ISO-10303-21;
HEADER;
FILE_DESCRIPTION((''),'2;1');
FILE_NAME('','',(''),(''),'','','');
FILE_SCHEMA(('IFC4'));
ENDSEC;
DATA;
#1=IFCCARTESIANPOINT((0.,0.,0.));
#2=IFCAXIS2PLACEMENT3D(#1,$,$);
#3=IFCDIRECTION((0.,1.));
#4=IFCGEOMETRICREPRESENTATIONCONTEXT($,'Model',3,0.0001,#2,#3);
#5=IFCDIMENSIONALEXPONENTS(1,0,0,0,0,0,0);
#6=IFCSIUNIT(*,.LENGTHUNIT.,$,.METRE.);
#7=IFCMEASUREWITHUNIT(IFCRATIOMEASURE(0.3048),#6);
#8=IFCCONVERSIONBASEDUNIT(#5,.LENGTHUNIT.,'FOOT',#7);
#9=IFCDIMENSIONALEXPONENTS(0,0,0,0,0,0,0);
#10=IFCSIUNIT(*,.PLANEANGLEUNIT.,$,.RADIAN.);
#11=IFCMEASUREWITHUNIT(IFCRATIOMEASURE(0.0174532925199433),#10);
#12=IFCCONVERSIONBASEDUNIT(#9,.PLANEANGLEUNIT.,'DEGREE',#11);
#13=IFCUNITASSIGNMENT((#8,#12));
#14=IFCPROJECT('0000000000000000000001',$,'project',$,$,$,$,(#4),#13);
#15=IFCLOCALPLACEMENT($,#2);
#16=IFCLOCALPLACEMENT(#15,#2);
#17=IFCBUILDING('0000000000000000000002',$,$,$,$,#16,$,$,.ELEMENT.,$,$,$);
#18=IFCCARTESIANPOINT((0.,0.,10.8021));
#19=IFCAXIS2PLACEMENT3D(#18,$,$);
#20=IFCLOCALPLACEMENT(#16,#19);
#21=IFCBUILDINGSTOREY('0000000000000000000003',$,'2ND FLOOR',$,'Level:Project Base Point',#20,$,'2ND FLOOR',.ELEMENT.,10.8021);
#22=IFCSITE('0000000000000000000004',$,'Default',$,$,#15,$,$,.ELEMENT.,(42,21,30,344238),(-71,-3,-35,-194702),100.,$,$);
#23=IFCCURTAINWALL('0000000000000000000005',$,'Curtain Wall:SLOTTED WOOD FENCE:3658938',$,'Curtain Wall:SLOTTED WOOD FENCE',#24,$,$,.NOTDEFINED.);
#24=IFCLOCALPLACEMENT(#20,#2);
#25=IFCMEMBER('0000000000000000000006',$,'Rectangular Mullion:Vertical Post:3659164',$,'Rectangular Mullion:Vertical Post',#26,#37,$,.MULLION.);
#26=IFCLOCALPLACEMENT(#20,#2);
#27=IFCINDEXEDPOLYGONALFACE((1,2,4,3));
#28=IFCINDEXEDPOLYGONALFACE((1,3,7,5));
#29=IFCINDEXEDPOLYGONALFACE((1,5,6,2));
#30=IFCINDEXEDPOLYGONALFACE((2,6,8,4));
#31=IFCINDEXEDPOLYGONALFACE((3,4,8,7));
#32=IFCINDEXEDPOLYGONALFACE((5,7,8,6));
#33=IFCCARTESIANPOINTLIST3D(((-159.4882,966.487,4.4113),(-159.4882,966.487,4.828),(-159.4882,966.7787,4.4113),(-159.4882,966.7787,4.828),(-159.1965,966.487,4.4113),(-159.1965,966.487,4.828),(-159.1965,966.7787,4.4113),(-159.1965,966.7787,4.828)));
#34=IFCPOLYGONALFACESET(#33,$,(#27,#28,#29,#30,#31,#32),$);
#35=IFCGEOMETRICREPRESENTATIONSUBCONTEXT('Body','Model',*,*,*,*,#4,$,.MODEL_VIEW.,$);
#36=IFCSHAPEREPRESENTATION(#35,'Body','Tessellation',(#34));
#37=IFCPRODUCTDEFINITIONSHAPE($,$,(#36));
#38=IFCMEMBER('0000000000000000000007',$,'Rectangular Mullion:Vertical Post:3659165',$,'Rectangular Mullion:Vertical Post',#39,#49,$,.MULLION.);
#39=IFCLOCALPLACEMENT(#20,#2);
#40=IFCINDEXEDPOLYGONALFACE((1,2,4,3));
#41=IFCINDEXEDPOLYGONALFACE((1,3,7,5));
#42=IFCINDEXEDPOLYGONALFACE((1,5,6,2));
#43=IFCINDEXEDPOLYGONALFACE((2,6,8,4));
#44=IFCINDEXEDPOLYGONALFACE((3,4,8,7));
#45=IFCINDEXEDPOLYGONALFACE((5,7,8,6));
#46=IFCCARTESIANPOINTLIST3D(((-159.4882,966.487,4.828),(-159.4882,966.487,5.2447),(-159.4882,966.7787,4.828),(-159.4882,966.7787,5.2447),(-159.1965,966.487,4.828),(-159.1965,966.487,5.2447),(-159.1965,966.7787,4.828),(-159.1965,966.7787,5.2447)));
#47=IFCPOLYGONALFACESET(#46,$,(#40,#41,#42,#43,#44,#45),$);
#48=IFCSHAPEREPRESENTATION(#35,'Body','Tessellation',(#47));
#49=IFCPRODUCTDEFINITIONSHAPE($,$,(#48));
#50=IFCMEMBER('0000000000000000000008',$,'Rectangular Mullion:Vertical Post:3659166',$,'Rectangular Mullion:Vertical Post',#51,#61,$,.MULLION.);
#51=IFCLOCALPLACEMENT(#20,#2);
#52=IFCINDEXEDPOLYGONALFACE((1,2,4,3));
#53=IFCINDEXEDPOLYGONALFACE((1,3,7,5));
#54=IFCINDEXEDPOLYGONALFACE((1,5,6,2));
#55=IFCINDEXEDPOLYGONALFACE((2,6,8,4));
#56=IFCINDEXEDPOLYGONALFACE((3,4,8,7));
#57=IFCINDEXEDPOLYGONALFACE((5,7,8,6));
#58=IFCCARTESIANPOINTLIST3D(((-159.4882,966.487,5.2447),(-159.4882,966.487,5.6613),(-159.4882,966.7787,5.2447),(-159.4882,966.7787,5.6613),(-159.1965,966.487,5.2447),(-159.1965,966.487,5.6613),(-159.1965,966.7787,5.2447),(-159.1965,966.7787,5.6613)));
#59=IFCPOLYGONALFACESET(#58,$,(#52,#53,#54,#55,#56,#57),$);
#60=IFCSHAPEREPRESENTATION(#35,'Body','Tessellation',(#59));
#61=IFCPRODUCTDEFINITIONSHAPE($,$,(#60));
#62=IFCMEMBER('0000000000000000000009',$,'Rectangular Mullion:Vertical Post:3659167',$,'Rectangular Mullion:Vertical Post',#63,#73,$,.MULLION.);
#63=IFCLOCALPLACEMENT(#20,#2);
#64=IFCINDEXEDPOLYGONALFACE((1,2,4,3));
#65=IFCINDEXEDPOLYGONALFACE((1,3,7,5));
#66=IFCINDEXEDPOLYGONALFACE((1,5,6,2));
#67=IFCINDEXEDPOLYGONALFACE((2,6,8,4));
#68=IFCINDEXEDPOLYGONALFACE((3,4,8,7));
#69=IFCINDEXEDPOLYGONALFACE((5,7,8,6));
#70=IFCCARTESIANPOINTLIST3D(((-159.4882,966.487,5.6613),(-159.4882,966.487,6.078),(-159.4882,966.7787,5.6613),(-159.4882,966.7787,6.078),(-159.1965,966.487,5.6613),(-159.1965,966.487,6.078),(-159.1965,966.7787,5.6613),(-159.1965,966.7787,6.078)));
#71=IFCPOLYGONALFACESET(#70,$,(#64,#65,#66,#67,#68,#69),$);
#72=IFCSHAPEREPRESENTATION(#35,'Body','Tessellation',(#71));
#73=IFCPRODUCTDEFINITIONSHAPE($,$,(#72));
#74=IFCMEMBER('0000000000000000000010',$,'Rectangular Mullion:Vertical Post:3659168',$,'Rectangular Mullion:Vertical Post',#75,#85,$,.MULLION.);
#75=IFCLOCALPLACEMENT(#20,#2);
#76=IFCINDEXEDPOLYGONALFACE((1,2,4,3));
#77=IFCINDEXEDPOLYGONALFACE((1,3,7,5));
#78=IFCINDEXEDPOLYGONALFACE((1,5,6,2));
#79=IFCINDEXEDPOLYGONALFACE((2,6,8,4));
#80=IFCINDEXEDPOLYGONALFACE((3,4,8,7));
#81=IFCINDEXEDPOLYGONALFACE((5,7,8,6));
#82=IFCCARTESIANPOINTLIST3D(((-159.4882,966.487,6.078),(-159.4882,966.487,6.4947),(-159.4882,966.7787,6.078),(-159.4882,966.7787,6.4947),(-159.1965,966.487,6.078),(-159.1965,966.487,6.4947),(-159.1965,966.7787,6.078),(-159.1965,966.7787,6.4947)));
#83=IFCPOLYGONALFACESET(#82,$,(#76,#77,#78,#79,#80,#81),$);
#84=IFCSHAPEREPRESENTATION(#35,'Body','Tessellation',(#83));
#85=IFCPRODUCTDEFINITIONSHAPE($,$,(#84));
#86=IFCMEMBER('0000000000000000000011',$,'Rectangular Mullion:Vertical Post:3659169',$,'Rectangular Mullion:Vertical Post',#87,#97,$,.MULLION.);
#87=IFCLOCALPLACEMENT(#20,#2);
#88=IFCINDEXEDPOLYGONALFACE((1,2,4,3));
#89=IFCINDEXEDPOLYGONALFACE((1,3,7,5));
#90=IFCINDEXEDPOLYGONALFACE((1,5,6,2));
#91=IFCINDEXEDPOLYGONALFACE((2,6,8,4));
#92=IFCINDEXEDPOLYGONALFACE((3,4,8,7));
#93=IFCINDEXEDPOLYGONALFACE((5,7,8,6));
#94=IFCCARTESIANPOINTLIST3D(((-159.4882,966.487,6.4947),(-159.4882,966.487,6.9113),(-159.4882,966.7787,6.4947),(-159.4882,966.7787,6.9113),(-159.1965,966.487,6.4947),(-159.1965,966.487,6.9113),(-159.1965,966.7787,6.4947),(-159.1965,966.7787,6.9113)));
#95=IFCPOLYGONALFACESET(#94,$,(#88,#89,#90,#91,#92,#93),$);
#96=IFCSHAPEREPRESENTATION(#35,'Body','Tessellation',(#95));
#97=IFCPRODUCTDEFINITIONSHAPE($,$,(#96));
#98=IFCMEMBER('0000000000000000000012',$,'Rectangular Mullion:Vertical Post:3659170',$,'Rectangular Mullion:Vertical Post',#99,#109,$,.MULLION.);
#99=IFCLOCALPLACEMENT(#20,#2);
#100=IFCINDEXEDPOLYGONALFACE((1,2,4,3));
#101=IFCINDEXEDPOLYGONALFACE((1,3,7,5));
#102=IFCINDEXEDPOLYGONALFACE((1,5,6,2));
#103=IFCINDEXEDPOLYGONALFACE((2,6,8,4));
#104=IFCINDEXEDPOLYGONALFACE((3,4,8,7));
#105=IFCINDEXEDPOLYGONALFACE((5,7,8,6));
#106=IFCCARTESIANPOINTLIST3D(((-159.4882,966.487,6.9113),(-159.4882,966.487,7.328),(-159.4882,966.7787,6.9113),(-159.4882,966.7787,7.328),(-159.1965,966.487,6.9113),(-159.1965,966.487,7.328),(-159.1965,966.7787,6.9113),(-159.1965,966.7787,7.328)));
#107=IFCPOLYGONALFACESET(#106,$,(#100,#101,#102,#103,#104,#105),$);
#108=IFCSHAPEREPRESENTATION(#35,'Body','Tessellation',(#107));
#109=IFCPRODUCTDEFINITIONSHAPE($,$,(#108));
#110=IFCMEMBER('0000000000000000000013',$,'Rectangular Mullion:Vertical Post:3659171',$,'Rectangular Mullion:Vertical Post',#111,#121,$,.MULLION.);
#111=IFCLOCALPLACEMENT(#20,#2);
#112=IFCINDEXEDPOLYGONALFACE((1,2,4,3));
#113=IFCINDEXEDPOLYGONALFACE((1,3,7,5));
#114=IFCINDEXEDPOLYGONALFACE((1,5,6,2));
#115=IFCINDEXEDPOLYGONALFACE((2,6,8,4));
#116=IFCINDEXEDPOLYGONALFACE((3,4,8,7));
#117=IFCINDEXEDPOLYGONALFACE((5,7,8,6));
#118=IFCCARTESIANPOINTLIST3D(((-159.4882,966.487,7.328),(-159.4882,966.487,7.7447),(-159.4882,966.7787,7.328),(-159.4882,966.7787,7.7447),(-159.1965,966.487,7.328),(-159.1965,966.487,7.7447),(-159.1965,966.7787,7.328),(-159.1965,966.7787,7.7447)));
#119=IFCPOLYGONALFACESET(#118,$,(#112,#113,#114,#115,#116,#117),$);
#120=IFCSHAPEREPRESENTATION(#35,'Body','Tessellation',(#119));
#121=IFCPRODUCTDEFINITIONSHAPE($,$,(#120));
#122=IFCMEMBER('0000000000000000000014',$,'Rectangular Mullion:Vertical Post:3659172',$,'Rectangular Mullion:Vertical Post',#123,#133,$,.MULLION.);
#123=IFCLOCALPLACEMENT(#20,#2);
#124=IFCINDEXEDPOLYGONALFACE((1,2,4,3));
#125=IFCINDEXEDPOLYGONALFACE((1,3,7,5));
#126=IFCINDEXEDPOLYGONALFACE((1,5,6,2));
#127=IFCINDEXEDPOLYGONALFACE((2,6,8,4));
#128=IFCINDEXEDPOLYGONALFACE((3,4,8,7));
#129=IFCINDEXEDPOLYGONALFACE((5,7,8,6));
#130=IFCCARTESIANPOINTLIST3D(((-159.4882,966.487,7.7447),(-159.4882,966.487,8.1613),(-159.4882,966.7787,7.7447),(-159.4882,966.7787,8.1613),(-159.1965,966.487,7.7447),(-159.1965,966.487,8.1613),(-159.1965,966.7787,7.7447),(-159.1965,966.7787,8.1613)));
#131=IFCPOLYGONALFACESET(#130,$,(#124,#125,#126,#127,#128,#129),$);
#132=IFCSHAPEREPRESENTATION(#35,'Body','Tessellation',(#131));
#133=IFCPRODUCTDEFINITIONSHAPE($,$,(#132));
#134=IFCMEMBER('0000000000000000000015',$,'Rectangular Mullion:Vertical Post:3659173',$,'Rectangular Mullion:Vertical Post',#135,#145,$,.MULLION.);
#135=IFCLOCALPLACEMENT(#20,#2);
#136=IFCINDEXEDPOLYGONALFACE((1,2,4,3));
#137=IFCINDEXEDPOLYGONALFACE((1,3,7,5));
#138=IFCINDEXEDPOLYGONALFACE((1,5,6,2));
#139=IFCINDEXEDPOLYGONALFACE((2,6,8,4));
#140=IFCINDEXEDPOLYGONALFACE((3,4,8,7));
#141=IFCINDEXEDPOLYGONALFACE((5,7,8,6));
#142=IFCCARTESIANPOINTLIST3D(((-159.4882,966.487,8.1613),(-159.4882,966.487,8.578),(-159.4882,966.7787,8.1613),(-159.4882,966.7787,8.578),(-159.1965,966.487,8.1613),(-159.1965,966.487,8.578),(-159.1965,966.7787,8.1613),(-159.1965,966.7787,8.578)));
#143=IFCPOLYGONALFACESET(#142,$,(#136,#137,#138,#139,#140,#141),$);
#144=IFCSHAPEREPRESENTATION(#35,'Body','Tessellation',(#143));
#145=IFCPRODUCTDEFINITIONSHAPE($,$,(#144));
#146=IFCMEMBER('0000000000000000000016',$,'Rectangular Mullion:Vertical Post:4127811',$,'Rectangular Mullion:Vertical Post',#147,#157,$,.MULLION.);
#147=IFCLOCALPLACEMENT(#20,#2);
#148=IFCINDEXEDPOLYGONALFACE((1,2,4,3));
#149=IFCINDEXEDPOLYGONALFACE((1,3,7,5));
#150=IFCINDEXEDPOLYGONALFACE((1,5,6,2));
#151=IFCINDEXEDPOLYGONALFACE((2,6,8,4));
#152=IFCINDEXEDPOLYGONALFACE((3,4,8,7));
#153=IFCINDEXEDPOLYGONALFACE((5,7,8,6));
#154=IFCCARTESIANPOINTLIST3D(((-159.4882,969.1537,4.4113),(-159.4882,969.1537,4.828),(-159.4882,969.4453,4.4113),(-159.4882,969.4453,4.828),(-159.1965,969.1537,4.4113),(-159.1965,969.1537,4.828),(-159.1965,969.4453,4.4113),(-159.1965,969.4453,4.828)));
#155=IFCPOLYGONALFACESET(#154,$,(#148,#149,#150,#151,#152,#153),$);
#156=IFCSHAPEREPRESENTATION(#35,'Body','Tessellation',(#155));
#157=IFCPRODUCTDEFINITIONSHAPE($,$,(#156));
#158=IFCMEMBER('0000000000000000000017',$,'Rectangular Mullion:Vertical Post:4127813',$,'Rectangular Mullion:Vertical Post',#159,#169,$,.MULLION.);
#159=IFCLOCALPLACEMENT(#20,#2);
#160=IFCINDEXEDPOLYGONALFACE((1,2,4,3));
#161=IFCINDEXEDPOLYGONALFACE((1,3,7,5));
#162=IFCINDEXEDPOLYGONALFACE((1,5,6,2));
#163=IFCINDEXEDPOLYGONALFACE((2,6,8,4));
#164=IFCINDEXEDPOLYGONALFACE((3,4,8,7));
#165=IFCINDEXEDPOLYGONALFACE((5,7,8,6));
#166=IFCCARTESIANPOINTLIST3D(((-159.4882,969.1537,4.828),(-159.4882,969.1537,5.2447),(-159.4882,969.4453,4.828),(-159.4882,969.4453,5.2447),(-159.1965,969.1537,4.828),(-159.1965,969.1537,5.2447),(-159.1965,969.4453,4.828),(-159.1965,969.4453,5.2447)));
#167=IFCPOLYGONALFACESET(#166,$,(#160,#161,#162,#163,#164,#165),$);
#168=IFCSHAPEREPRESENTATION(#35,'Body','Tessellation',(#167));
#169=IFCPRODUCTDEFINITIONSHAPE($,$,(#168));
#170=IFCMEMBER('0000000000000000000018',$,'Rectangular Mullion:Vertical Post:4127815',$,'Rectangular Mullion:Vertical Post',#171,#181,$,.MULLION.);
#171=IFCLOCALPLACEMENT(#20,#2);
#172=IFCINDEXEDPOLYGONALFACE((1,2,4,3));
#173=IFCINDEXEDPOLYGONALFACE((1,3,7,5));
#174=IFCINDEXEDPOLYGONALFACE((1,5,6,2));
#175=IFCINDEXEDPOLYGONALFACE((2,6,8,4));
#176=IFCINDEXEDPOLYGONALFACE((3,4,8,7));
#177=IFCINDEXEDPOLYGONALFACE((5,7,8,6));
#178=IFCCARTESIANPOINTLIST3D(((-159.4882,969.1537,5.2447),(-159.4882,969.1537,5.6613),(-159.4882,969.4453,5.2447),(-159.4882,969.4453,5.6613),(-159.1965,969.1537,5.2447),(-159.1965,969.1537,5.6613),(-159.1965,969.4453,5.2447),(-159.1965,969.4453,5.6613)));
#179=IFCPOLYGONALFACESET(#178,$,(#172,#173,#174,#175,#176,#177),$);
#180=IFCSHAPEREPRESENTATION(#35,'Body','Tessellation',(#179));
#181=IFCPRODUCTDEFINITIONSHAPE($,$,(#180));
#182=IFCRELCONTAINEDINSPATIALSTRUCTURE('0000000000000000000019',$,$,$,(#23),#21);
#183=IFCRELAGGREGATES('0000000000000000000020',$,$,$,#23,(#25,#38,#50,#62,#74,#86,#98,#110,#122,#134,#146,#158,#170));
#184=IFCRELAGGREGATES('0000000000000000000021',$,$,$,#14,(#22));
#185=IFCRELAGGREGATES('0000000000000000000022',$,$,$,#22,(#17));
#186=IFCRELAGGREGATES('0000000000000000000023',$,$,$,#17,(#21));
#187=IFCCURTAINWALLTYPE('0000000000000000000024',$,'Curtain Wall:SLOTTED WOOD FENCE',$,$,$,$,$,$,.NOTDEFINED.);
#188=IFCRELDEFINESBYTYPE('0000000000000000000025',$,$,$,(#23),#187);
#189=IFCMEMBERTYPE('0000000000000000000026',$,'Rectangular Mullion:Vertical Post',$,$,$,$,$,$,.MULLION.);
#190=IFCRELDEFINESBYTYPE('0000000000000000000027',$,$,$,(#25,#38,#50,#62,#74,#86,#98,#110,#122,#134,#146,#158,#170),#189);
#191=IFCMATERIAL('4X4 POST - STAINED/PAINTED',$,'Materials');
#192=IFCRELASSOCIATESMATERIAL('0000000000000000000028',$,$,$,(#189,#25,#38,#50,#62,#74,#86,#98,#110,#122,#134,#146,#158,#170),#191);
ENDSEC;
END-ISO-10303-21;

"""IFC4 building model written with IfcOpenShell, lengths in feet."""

from ifc_helpers import new_model, entity, si_unit, converted_unit, direction, frame, origin, origin_2d_with_axis, place, context, subcontext, project, spatial, rectangle, extrude, source, transform, mapped, material, material_profile, profile_set, profile_usage, type_object, type_shapes, element, aggregate, save


model = new_model("IFC4")

# Units and contexts
model_context = context("Model", 3, precision=0.0001, world=origin(), true_north=direction((0.0, 1.0)))
body_context = subcontext(model_context, "Body", "Model", "MODEL_VIEW")
ifc_project = project(units=[converted_unit("LENGTHUNIT", "FOOT", entity("IfcRatioMeasure", 0.3048), si_unit("LENGTHUNIT", "METRE"), dimensions=[1, 0, 0, 0, 0, 0, 0]), converted_unit("PLANEANGLEUNIT", "DEGREE", entity("IfcRatioMeasure", 0.0174532925199433), si_unit("PLANEANGLEUNIT", "RADIAN"), dimensions=[0, 0, 0, 0, 0, 0, 0])], contexts=[model_context])

# Site, building, storey
site_placement = place(None, origin())
site = spatial("IfcSite", under=ifc_project, at=site_placement, Name="Default", CompositionType="ELEMENT", RefLatitude=(42, 21, 30, 344238), RefLongitude=(-71, -3, -35, -194702), RefElevation=100.0)
building_placement = place(site_placement, origin())
building = spatial("IfcBuilding", under=site, at=building_placement, CompositionType="ELEMENT")
storey_placement = place(building_placement, frame((0.0, 0.0, 10.8021)))
storey = spatial("IfcBuildingStorey", under=building, at=storey_placement, Name="2ND FLOOR", ObjectType="Level:Project Base Point", LongName="2ND FLOOR", CompositionType="ELEMENT", Elevation=10.8021)

# Curtain wall, members
curtain_wall_type_1 = type_object("IfcCurtainWallType", Name="Curtain Wall:SLOTTED WOOD FENCE", PredefinedType="NOTDEFINED")
curtain_wall_1_placement = place(storey_placement, frame((0.0, 0.0, -10.8021)))
curtain_wall_1 = element("IfcCurtainWall", 1, at=curtain_wall_1_placement, inside=storey, type_object=curtain_wall_type_1, Name="Curtain Wall:SLOTTED WOOD FENCE:3658938", ObjectType="Curtain Wall:SLOTTED WOOD FENCE", PredefinedType="NOTDEFINED")
ifc_material_1 = material(Name="4X4 POST - STAINED/PAINTED", Category="Materials")
ifc_material_profile_1 = material_profile(ifc_material_1, rectangle(XDim=0.2917, YDim=0.2917, at=origin_2d_with_axis()), Name="Vertical Post")
ifc_profile_set_1 = profile_set([ifc_material_profile_1], Name="Vertical Post")
ifc_profile_usage_1 = profile_usage(ifc_profile_set_1)
member_type_1 = type_object("IfcMemberType", Name="Rectangular Mullion:Vertical Post", PredefinedType="MULLION", material=ifc_profile_set_1)
shared_shape_1 = source(origin(), body_context, "Body", "SweptSolid", [
    extrude(rectangle(XDim=0.2917, YDim=0.2917, at=origin_2d_with_axis()), frame((0.0, -0.2083, -0.4167), z_axis=(0.0, 0.0, 1.0), x_axis=(0.0, -1.0, 0.0)), (0.0, 0.0, 1.0), 0.4167),
])
type_shapes(member_type_1, [shared_shape_1])
member_1_placement = place(storey_placement, frame((-159.5507, 966.6328, 4.4113), z_axis=(0.0, 0.0, -1.0), x_axis=(0.0, -1.0, 0.0)))
member_1 = element("IfcMember", 2, at=member_1_placement, type_object=member_type_1, material=ifc_profile_usage_1, Name="Rectangular Mullion:Vertical Post:3659164", ObjectType="Rectangular Mullion:Vertical Post", PredefinedType="MULLION", context=body_context, shape_type="MappedRepresentation", body=[
    mapped(shared_shape_1, transform((0.0, 0.0, 0.0), scale=1.0)),
])
ifc_profile_usage_2 = profile_usage(ifc_profile_set_1)
member_2_placement = place(storey_placement, frame((-159.5507, 966.6328, 4.828), z_axis=(0.0, 0.0, -1.0), x_axis=(0.0, -1.0, 0.0)))
member_2 = element("IfcMember", 3, at=member_2_placement, type_object=member_type_1, material=ifc_profile_usage_2, Name="Rectangular Mullion:Vertical Post:3659165", ObjectType="Rectangular Mullion:Vertical Post", PredefinedType="MULLION", context=body_context, shape_type="MappedRepresentation", body=[
    mapped(shared_shape_1, transform((0.0, 0.0, 0.0), scale=1.0)),
])
ifc_profile_usage_3 = profile_usage(ifc_profile_set_1)
member_3_placement = place(storey_placement, frame((-159.5507, 966.6328, 5.2447), z_axis=(0.0, 0.0, -1.0), x_axis=(0.0, -1.0, 0.0)))
member_3 = element("IfcMember", 4, at=member_3_placement, type_object=member_type_1, material=ifc_profile_usage_3, Name="Rectangular Mullion:Vertical Post:3659166", ObjectType="Rectangular Mullion:Vertical Post", PredefinedType="MULLION", context=body_context, shape_type="MappedRepresentation", body=[
    mapped(shared_shape_1, transform((0.0, 0.0, 0.0), scale=1.0)),
])
ifc_profile_usage_4 = profile_usage(ifc_profile_set_1)
member_4_placement = place(storey_placement, frame((-159.5507, 966.6328, 5.6613), z_axis=(0.0, 0.0, -1.0), x_axis=(0.0, -1.0, 0.0)))
member_4 = element("IfcMember", 5, at=member_4_placement, type_object=member_type_1, material=ifc_profile_usage_4, Name="Rectangular Mullion:Vertical Post:3659167", ObjectType="Rectangular Mullion:Vertical Post", PredefinedType="MULLION", context=body_context, shape_type="MappedRepresentation", body=[
    mapped(shared_shape_1, transform((0.0, 0.0, 0.0), scale=1.0)),
])
ifc_profile_usage_5 = profile_usage(ifc_profile_set_1)
member_5_placement = place(storey_placement, frame((-159.5507, 966.6328, 6.078), z_axis=(0.0, 0.0, -1.0), x_axis=(0.0, -1.0, 0.0)))
member_5 = element("IfcMember", 6, at=member_5_placement, type_object=member_type_1, material=ifc_profile_usage_5, Name="Rectangular Mullion:Vertical Post:3659168", ObjectType="Rectangular Mullion:Vertical Post", PredefinedType="MULLION", context=body_context, shape_type="MappedRepresentation", body=[
    mapped(shared_shape_1, transform((0.0, 0.0, 0.0), scale=1.0)),
])
ifc_profile_usage_6 = profile_usage(ifc_profile_set_1)
member_6_placement = place(storey_placement, frame((-159.5507, 966.6328, 6.4947), z_axis=(0.0, 0.0, -1.0), x_axis=(0.0, -1.0, 0.0)))
member_6 = element("IfcMember", 7, at=member_6_placement, type_object=member_type_1, material=ifc_profile_usage_6, Name="Rectangular Mullion:Vertical Post:3659169", ObjectType="Rectangular Mullion:Vertical Post", PredefinedType="MULLION", context=body_context, shape_type="MappedRepresentation", body=[
    mapped(shared_shape_1, transform((0.0, 0.0, 0.0), scale=1.0)),
])
ifc_profile_usage_7 = profile_usage(ifc_profile_set_1)
member_7_placement = place(storey_placement, frame((-159.5507, 966.6328, 6.9113), z_axis=(0.0, 0.0, -1.0), x_axis=(0.0, -1.0, 0.0)))
member_7 = element("IfcMember", 8, at=member_7_placement, type_object=member_type_1, material=ifc_profile_usage_7, Name="Rectangular Mullion:Vertical Post:3659170", ObjectType="Rectangular Mullion:Vertical Post", PredefinedType="MULLION", context=body_context, shape_type="MappedRepresentation", body=[
    mapped(shared_shape_1, transform((0.0, 0.0, 0.0), scale=1.0)),
])
ifc_profile_usage_8 = profile_usage(ifc_profile_set_1)
member_8_placement = place(storey_placement, frame((-159.5507, 966.6328, 7.328), z_axis=(0.0, 0.0, -1.0), x_axis=(0.0, -1.0, 0.0)))
member_8 = element("IfcMember", 9, at=member_8_placement, type_object=member_type_1, material=ifc_profile_usage_8, Name="Rectangular Mullion:Vertical Post:3659171", ObjectType="Rectangular Mullion:Vertical Post", PredefinedType="MULLION", context=body_context, shape_type="MappedRepresentation", body=[
    mapped(shared_shape_1, transform((0.0, 0.0, 0.0), scale=1.0)),
])
ifc_profile_usage_9 = profile_usage(ifc_profile_set_1)
member_9_placement = place(storey_placement, frame((-159.5507, 966.6328, 7.7447), z_axis=(0.0, 0.0, -1.0), x_axis=(0.0, -1.0, 0.0)))
member_9 = element("IfcMember", 10, at=member_9_placement, type_object=member_type_1, material=ifc_profile_usage_9, Name="Rectangular Mullion:Vertical Post:3659172", ObjectType="Rectangular Mullion:Vertical Post", PredefinedType="MULLION", context=body_context, shape_type="MappedRepresentation", body=[
    mapped(shared_shape_1, transform((0.0, 0.0, 0.0), scale=1.0)),
])
ifc_profile_usage_10 = profile_usage(ifc_profile_set_1)
member_10_placement = place(storey_placement, frame((-159.5507, 966.6328, 8.1613), z_axis=(0.0, 0.0, -1.0), x_axis=(0.0, -1.0, 0.0)))
member_10 = element("IfcMember", 11, at=member_10_placement, type_object=member_type_1, material=ifc_profile_usage_10, Name="Rectangular Mullion:Vertical Post:3659173", ObjectType="Rectangular Mullion:Vertical Post", PredefinedType="MULLION", context=body_context, shape_type="MappedRepresentation", body=[
    mapped(shared_shape_1, transform((0.0, 0.0, 0.0), scale=1.0)),
])
ifc_profile_usage_11 = profile_usage(ifc_profile_set_1)
member_11_placement = place(storey_placement, frame((-159.5507, 969.2995, 4.4113), z_axis=(0.0, 0.0, -1.0), x_axis=(0.0, -1.0, 0.0)))
member_11 = element("IfcMember", 12, at=member_11_placement, type_object=member_type_1, material=ifc_profile_usage_11, Name="Rectangular Mullion:Vertical Post:4127811", ObjectType="Rectangular Mullion:Vertical Post", PredefinedType="MULLION", context=body_context, shape_type="MappedRepresentation", body=[
    mapped(shared_shape_1, transform((0.0, 0.0, 0.0), scale=1.0)),
])
ifc_profile_usage_12 = profile_usage(ifc_profile_set_1)
member_12_placement = place(storey_placement, frame((-159.5507, 969.2995, 4.828), z_axis=(0.0, 0.0, -1.0), x_axis=(0.0, -1.0, 0.0)))
member_12 = element("IfcMember", 13, at=member_12_placement, type_object=member_type_1, material=ifc_profile_usage_12, Name="Rectangular Mullion:Vertical Post:4127813", ObjectType="Rectangular Mullion:Vertical Post", PredefinedType="MULLION", context=body_context, shape_type="MappedRepresentation", body=[
    mapped(shared_shape_1, transform((0.0, 0.0, 0.0), scale=1.0)),
])
ifc_profile_usage_13 = profile_usage(ifc_profile_set_1)
member_13_placement = place(storey_placement, frame((-159.5507, 969.2995, 5.2447), z_axis=(0.0, 0.0, -1.0), x_axis=(0.0, -1.0, 0.0)))
member_13 = element("IfcMember", 14, at=member_13_placement, type_object=member_type_1, material=ifc_profile_usage_13, Name="Rectangular Mullion:Vertical Post:4127815", ObjectType="Rectangular Mullion:Vertical Post", PredefinedType="MULLION", context=body_context, shape_type="MappedRepresentation", body=[
    mapped(shared_shape_1, transform((0.0, 0.0, 0.0), scale=1.0)),
])

aggregate(curtain_wall_1, [member_1, member_2, member_3, member_4, member_5, member_6, member_7, member_8, member_9, member_10, member_11, member_12, member_13])

save(model, "model.ifc")
